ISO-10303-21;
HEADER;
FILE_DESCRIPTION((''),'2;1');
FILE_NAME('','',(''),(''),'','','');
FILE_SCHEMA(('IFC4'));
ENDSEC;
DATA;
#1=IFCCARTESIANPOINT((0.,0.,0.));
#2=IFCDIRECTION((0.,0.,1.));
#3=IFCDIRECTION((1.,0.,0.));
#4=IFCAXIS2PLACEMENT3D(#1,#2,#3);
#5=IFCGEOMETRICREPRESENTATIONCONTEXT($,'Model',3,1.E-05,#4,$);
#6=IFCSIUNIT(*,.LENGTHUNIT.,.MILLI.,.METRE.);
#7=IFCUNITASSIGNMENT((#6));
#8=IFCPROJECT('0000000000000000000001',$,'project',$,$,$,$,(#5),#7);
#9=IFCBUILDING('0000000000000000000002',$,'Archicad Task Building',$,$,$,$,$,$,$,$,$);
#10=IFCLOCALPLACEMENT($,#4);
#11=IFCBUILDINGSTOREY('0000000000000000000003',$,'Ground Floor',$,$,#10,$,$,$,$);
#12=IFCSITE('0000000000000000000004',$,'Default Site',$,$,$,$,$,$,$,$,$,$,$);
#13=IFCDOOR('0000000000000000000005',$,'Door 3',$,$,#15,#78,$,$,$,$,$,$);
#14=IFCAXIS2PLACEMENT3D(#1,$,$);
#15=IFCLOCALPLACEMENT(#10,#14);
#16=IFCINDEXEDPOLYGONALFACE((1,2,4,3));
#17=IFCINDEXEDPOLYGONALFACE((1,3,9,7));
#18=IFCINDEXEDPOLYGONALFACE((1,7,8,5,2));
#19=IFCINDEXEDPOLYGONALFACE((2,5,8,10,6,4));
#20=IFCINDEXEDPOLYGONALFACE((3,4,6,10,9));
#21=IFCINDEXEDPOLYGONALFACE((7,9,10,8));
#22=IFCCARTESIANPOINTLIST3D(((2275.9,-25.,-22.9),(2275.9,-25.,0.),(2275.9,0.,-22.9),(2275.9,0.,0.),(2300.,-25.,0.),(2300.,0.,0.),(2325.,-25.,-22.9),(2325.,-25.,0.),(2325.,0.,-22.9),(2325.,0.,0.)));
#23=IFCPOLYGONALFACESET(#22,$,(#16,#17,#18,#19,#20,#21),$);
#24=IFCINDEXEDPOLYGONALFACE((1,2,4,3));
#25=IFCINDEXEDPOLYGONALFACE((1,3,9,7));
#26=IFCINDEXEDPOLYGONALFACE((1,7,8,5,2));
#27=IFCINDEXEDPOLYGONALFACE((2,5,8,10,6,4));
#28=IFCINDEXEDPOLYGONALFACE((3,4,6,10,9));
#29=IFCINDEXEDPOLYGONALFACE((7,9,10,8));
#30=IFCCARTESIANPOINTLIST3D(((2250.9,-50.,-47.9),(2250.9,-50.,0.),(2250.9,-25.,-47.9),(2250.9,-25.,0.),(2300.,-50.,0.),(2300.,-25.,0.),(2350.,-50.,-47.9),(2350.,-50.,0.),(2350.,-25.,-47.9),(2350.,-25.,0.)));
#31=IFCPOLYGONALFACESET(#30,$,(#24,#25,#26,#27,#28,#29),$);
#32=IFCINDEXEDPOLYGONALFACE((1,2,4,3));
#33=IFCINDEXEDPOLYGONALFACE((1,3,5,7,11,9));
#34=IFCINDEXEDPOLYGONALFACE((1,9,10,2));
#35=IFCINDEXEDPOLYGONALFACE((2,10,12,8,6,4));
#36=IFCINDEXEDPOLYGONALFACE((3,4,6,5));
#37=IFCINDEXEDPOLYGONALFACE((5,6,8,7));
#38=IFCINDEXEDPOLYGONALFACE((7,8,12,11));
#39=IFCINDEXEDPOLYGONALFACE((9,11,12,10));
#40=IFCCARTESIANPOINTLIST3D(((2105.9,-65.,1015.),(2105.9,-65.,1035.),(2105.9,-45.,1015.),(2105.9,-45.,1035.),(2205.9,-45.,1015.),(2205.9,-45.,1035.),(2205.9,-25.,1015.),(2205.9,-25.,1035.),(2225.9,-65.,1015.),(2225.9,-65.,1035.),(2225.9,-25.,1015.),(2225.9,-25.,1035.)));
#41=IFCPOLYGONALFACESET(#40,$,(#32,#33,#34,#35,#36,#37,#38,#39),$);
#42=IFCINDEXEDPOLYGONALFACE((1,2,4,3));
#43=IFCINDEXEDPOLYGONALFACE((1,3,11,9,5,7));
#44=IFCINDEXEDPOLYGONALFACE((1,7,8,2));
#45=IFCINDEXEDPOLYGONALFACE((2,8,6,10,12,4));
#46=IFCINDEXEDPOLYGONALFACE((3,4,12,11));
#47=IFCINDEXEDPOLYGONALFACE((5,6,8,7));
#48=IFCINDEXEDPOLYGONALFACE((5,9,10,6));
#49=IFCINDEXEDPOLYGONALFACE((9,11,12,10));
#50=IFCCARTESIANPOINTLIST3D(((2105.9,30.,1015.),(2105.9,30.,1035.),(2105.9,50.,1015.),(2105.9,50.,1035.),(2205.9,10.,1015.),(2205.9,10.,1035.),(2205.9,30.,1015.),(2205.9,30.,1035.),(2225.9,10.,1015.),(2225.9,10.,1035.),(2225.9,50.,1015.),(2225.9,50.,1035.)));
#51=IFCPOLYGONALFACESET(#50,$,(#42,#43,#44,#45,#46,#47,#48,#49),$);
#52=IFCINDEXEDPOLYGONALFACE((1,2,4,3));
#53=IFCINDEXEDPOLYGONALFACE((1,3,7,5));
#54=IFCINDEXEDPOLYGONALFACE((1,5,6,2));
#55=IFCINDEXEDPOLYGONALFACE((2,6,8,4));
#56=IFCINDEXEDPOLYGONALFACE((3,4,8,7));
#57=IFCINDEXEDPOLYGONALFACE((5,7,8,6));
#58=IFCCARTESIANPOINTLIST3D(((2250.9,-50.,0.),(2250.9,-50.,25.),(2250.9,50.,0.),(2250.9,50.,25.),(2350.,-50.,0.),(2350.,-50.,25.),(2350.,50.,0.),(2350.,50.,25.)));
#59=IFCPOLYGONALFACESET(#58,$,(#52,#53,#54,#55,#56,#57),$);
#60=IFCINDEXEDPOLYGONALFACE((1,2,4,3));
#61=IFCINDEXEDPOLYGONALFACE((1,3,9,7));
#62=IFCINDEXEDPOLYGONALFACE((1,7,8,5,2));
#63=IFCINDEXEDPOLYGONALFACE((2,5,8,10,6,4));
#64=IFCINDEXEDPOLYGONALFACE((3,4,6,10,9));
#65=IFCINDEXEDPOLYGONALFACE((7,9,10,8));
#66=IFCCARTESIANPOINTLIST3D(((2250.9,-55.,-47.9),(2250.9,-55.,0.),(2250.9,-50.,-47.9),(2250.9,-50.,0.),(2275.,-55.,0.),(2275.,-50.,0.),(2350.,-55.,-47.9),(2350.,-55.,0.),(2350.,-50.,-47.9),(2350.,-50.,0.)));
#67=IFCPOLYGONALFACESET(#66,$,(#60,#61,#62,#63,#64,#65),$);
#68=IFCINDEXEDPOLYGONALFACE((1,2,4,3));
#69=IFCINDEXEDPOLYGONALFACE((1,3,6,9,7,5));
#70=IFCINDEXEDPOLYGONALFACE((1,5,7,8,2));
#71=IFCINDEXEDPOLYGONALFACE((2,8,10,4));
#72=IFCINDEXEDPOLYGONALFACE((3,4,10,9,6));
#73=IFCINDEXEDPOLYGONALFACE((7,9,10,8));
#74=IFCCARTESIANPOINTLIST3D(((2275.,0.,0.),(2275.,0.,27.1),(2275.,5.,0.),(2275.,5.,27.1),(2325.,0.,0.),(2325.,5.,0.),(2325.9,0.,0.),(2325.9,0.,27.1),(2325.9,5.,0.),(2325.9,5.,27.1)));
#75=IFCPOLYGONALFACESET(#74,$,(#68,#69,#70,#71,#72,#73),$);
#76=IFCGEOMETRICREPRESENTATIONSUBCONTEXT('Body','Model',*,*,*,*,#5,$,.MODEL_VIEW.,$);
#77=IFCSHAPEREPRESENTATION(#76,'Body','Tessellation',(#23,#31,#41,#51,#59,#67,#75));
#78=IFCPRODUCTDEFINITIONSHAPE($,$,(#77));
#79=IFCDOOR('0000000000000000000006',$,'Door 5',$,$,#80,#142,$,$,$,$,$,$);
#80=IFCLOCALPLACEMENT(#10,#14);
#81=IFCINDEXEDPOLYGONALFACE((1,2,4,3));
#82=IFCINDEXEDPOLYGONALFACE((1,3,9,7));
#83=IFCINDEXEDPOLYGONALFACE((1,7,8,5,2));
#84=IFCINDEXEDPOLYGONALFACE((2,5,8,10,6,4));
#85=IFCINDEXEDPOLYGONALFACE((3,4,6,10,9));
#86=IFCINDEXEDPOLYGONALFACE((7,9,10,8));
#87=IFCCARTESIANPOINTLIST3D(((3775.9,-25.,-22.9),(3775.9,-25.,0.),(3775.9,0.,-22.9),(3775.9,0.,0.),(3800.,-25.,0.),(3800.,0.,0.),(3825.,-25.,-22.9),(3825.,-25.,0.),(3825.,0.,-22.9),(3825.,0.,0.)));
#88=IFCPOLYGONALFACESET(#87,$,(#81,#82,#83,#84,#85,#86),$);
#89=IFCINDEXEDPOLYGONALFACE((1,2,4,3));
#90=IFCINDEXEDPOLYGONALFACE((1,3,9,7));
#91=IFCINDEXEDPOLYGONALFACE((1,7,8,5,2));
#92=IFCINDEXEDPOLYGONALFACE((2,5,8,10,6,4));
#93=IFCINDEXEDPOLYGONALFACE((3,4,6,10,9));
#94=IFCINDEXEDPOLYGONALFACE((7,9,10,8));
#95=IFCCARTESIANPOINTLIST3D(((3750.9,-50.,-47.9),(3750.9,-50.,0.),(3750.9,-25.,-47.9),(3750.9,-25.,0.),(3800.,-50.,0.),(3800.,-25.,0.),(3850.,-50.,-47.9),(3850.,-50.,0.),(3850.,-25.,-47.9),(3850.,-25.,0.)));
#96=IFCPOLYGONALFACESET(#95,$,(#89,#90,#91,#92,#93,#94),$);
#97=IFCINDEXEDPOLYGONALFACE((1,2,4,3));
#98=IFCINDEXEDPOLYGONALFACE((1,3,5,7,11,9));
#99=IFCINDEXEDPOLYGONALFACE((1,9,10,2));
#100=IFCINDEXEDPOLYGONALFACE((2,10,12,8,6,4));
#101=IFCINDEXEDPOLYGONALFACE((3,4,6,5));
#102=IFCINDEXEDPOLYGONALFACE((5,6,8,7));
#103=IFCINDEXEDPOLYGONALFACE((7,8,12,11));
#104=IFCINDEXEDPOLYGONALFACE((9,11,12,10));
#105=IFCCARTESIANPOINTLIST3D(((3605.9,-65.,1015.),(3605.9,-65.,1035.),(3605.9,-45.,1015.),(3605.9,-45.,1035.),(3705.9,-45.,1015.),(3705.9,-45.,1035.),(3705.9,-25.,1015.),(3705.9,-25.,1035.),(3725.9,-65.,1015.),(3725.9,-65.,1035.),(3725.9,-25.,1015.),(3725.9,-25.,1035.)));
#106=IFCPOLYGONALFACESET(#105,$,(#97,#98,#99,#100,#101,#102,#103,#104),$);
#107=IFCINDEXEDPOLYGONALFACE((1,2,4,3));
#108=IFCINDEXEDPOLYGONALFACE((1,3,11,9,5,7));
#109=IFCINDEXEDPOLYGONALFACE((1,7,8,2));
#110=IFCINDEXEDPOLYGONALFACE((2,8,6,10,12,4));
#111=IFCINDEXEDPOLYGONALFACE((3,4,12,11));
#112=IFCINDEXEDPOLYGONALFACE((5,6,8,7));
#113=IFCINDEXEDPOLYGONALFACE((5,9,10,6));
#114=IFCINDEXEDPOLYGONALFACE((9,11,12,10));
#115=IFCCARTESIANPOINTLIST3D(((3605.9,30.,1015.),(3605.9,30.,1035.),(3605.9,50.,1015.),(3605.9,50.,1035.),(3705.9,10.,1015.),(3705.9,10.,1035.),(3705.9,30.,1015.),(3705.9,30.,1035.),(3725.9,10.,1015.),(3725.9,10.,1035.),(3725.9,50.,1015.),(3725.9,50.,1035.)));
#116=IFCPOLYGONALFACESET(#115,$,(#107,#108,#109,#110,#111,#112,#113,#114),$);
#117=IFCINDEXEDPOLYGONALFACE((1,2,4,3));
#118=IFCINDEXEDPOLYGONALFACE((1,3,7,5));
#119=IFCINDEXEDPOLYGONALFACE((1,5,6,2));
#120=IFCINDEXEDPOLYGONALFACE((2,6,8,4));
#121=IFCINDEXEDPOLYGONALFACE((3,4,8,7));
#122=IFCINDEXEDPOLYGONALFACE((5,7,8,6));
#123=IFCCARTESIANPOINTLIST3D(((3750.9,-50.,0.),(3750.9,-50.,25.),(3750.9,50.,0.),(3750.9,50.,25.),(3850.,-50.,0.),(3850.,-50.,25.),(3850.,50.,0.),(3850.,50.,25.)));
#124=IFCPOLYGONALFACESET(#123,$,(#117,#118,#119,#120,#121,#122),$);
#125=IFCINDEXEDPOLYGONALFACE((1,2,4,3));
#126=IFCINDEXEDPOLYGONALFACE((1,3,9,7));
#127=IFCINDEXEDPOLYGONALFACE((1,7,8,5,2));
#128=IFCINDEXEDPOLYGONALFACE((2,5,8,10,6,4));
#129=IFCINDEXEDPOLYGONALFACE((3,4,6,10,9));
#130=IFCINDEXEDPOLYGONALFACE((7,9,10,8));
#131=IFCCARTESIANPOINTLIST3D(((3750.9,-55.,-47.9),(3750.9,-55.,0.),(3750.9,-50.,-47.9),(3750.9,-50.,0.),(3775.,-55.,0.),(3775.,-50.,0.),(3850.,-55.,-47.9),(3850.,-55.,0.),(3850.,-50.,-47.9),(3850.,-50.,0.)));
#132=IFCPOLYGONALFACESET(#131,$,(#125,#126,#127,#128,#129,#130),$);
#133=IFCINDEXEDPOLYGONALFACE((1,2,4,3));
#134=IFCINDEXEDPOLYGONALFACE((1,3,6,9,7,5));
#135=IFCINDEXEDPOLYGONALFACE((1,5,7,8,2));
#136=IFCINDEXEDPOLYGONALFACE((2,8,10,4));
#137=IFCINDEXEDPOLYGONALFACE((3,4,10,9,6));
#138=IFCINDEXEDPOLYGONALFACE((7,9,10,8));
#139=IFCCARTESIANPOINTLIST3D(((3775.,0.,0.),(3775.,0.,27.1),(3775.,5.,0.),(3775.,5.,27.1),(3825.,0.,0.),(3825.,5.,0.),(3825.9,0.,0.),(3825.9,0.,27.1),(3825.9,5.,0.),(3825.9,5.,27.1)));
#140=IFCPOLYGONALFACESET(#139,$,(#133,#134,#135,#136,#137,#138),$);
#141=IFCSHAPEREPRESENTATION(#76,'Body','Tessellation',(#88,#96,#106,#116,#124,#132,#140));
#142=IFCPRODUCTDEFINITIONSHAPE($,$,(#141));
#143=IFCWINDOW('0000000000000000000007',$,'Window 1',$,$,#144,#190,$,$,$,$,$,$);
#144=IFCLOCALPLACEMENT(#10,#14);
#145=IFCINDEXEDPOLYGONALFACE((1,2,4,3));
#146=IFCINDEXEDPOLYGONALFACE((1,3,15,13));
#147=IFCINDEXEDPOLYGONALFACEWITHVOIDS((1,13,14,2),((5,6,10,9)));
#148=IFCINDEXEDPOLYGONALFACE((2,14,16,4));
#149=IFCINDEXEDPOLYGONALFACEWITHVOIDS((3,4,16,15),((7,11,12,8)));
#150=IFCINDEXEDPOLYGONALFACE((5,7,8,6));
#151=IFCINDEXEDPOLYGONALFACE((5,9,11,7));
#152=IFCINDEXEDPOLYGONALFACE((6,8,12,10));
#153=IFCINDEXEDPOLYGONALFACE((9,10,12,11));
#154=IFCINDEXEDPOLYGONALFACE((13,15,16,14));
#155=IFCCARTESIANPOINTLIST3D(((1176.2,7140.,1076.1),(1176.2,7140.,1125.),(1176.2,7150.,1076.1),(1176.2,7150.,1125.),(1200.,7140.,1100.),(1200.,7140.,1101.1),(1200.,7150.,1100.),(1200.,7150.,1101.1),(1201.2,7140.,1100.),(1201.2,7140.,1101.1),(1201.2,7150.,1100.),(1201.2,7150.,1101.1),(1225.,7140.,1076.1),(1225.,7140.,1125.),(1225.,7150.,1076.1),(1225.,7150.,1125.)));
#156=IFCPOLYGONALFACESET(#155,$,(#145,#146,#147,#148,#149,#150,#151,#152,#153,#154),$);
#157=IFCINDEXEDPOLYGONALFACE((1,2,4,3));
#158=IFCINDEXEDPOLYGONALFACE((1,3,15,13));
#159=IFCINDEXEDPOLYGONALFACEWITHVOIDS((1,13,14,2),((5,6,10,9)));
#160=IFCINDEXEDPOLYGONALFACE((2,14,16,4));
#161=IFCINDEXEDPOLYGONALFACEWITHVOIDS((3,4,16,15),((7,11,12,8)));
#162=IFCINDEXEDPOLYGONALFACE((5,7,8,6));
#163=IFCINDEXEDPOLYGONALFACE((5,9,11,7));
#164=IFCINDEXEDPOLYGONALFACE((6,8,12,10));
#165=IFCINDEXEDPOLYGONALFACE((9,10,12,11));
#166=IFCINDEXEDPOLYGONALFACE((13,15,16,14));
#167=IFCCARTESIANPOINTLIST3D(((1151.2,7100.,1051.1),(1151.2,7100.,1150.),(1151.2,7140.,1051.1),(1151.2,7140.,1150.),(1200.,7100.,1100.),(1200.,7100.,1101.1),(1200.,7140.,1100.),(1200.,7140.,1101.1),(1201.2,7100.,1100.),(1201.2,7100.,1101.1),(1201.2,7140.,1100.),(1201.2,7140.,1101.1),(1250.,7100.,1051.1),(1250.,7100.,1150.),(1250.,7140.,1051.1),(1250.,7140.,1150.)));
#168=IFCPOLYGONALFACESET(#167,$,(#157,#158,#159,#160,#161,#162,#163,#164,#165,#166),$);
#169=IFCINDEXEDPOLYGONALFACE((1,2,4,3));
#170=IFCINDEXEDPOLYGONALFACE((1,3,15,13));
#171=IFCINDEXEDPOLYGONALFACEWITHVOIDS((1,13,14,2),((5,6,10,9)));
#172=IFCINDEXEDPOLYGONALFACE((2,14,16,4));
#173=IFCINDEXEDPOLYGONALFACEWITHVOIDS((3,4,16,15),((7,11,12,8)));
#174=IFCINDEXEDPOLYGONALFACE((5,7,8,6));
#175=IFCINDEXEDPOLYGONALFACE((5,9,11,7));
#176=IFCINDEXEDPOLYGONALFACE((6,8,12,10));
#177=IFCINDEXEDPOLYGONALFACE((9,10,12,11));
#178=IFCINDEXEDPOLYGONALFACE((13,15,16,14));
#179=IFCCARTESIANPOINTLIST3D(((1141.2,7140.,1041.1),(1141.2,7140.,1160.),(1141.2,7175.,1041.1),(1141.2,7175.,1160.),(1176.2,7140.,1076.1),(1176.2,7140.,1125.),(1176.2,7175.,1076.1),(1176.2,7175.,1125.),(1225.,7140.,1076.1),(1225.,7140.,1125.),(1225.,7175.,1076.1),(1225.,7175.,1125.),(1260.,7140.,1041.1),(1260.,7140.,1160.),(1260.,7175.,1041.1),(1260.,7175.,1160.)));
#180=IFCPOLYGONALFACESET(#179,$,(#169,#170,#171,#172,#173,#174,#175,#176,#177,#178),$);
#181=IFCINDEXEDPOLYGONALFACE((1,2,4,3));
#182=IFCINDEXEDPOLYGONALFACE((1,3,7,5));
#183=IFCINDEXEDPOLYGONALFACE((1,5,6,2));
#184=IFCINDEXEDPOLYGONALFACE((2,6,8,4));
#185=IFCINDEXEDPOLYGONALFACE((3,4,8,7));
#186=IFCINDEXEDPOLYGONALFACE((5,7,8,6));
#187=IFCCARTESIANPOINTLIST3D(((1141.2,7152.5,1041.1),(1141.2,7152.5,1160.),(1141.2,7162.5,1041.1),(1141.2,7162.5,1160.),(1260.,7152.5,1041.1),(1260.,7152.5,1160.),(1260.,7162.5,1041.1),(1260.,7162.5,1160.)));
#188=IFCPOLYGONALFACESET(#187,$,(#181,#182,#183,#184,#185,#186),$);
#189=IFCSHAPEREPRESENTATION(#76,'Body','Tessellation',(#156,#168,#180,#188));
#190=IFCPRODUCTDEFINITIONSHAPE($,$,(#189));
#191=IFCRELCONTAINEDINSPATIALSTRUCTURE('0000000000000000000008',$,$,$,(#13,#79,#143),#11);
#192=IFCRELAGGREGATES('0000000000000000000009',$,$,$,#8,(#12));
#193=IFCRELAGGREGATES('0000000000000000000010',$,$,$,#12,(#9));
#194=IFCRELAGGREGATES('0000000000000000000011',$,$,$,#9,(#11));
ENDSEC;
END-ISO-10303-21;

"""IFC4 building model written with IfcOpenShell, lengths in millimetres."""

from ifc_helpers import new_model, si_unit, frame, origin_with_axes, place, context, subcontext, project, spatial, line, indexed_curve, outline, extrude, element, save


model = new_model("IFC4")

# Units and contexts
model_context = context("Model", 3, precision=1e-05, world=origin_with_axes())
body_context = subcontext(model_context, "Body", "Model", "MODEL_VIEW")
ifc_project = project(units=[si_unit("LENGTHUNIT", "METRE", prefix="MILLI")], contexts=[model_context])

# Site, building, storey
site = spatial("IfcSite", under=ifc_project, Name="Default Site")
building = spatial("IfcBuilding", under=site, Name="Archicad Task Building")
storey_placement = place(None, origin_with_axes())
storey = spatial("IfcBuildingStorey", under=building, at=storey_placement, Name="Ground Floor")

# Doors
door_1_placement = place(storey_placement, frame((2300.0, -50.0, 0.0), z_axis=(0.0, 0.0, 1.0), x_axis=(1.0, 0.0, 0.0)))
element("IfcDoor", 1, at=door_1_placement, inside=storey, Name="Door 3", context=body_context, shape_type="SweptSolid", body=[
    extrude(outline(indexed_curve([(0.0, 0.0), (0.0, 2.1), (0.9, 2.1), (0.9, 0.0), (-24.1, 0.0), (-24.1, -22.9), (25.0, -22.9), (25.0, 0.0)], segments=[line(1, 2, 3, 4, 5, 6, 7, 8, 1)])), frame((0.0, 25.0, 0.0), z_axis=(0.0, -1.0, 0.0), x_axis=(1.0, 0.0, 0.0)), (0.0, 0.0, -1.0), 25.0),
    extrude(outline(indexed_curve([(0.0, 0.0), (0.0, 2.1), (0.9, 2.1), (0.9, 0.0), (-49.1, 0.0), (-49.1, -47.9), (50.0, -47.9), (50.0, 0.0)], segments=[line(1, 2, 3, 4, 5, 6, 7, 8, 1)])), frame((0.0, 0.0, 0.0), z_axis=(0.0, -1.0, 0.0), x_axis=(1.0, 0.0, 0.0)), (0.0, 0.0, -1.0), 25.0),
    extrude(outline(indexed_curve([(0.0, 0.0), (-49.1, 0.0), (-49.1, 35.0), (0.0, 35.0)], segments=[line(1, 2, 3, 4, 1)])), frame((25.0, 25.0, 25.0), z_axis=(0.0, 0.0, 1.0), x_axis=(1.0, 0.0, 0.0)), (0.0, 0.0, 1.0), -47.9),
    extrude(outline(indexed_curve([(0.0, 0.0), (0.0, -40.0), (-120.0, -40.0), (-120.0, -20.0), (-20.0, -20.0), (-20.0, 0.0)], segments=[line(1, 2, 3, 4, 5, 6, 1)])), frame((-74.1, 25.0, 1015.0), z_axis=(0.0, 0.0, 1.0), x_axis=(1.0, 0.0, 0.0)), (0.0, 0.0, 1.0), 20.0),
    extrude(outline(indexed_curve([(0.0, 0.0), (0.0, 40.0), (-120.0, 40.0), (-120.0, 20.0), (-20.0, 20.0), (-20.0, 0.0)], segments=[line(1, 2, 3, 4, 5, 6, 1)])), frame((-74.1, 60.0, 1015.0), z_axis=(0.0, 0.0, 1.0), x_axis=(1.0, 0.0, 0.0)), (0.0, 0.0, 1.0), 20.0),
    extrude(outline(indexed_curve([(0.0, 0.0), (-99.1, 0.0), (-99.1, 100.0), (0.0, 100.0)], segments=[line(1, 2, 3, 4, 1)])), frame((50.0, 0.0, 0.0), z_axis=(0.0, 0.0, 1.0), x_axis=(1.0, 0.0, 0.0)), (0.0, 0.0, 1.0), 25.0),
    extrude(outline(indexed_curve([(0.0, 0.0), (0.0, 27.1), (50.9, 27.1), (50.9, 0.0), (-24.1, 0.0), (-24.1, -47.9), (75.0, -47.9), (75.0, 0.0)], segments=[line(1, 2, 3, 4, 5, 6, 7, 8, 1)])), frame((-25.0, -5.0, 0.0), z_axis=(0.0, -1.0, 0.0), x_axis=(1.0, 0.0, 0.0)), (0.0, 0.0, -1.0), 5.0),
    extrude(outline(indexed_curve([(0.0, 0.0), (0.0, 27.1), (50.9, 27.1), (50.9, 0.0), (0.9, 0.0), (0.9, -22.9), (50.0, -22.9), (50.0, 0.0)], segments=[line(1, 2, 3, 4, 5, 6, 7, 8, 1)])), frame((-25.0, 50.0, 0.0), z_axis=(0.0, -1.0, 0.0), x_axis=(1.0, 0.0, 0.0)), (0.0, 0.0, -1.0), 5.0),
])
door_2_placement = place(storey_placement, frame((3800.0, -50.0, 0.0), z_axis=(0.0, 0.0, 1.0), x_axis=(1.0, 0.0, 0.0)))
element("IfcDoor", 2, at=door_2_placement, inside=storey, Name="Door 5", context=body_context, shape_type="SweptSolid", body=[
    extrude(outline(indexed_curve([(0.0, 0.0), (0.0, 2.1), (0.9, 2.1), (0.9, 0.0), (-24.1, 0.0), (-24.1, -22.9), (25.0, -22.9), (25.0, 0.0)], segments=[line(1, 2, 3, 4, 5, 6, 7, 8, 1)])), frame((0.0, 25.0, 0.0), z_axis=(0.0, -1.0, 0.0), x_axis=(1.0, 0.0, 0.0)), (0.0, 0.0, -1.0), 25.0),
    extrude(outline(indexed_curve([(0.0, 0.0), (0.0, 2.1), (0.9, 2.1), (0.9, 0.0), (-49.1, 0.0), (-49.1, -47.9), (50.0, -47.9), (50.0, 0.0)], segments=[line(1, 2, 3, 4, 5, 6, 7, 8, 1)])), frame((0.0, 0.0, 0.0), z_axis=(0.0, -1.0, 0.0), x_axis=(1.0, 0.0, 0.0)), (0.0, 0.0, -1.0), 25.0),
    extrude(outline(indexed_curve([(0.0, 0.0), (-49.1, 0.0), (-49.1, 35.0), (0.0, 35.0)], segments=[line(1, 2, 3, 4, 1)])), frame((25.0, 25.0, 25.0), z_axis=(0.0, 0.0, 1.0), x_axis=(1.0, 0.0, 0.0)), (0.0, 0.0, 1.0), -47.9),
    extrude(outline(indexed_curve([(0.0, 0.0), (0.0, -40.0), (-120.0, -40.0), (-120.0, -20.0), (-20.0, -20.0), (-20.0, 0.0)], segments=[line(1, 2, 3, 4, 5, 6, 1)])), frame((-74.1, 25.0, 1015.0), z_axis=(0.0, 0.0, 1.0), x_axis=(1.0, 0.0, 0.0)), (0.0, 0.0, 1.0), 20.0),
    extrude(outline(indexed_curve([(0.0, 0.0), (0.0, 40.0), (-120.0, 40.0), (-120.0, 20.0), (-20.0, 20.0), (-20.0, 0.0)], segments=[line(1, 2, 3, 4, 5, 6, 1)])), frame((-74.1, 60.0, 1015.0), z_axis=(0.0, 0.0, 1.0), x_axis=(1.0, 0.0, 0.0)), (0.0, 0.0, 1.0), 20.0),
    extrude(outline(indexed_curve([(0.0, 0.0), (-99.1, 0.0), (-99.1, 100.0), (0.0, 100.0)], segments=[line(1, 2, 3, 4, 1)])), frame((50.0, 0.0, 0.0), z_axis=(0.0, 0.0, 1.0), x_axis=(1.0, 0.0, 0.0)), (0.0, 0.0, 1.0), 25.0),
    extrude(outline(indexed_curve([(0.0, 0.0), (0.0, 27.1), (50.9, 27.1), (50.9, 0.0), (-24.1, 0.0), (-24.1, -47.9), (75.0, -47.9), (75.0, 0.0)], segments=[line(1, 2, 3, 4, 5, 6, 7, 8, 1)])), frame((-25.0, -5.0, 0.0), z_axis=(0.0, -1.0, 0.0), x_axis=(1.0, 0.0, 0.0)), (0.0, 0.0, -1.0), 5.0),
    extrude(outline(indexed_curve([(0.0, 0.0), (0.0, 27.1), (50.9, 27.1), (50.9, 0.0), (0.9, 0.0), (0.9, -22.9), (50.0, -22.9), (50.0, 0.0)], segments=[line(1, 2, 3, 4, 5, 6, 7, 8, 1)])), frame((-25.0, 50.0, 0.0), z_axis=(0.0, -1.0, 0.0), x_axis=(1.0, 0.0, 0.0)), (0.0, 0.0, -1.0), 5.0),
])

# Window
for number, where, z_axis, x_axis, name in (
    (3, (1200.0, 7050.0, 1100.0), (0.0, 0.0, 1.0), (1.0, 0.0, 0.0), "Window 1"),
):
    element("IfcWindow", number, at=place(storey_placement, frame(where, z_axis=z_axis, x_axis=x_axis)), inside=storey, Name=name, context=body_context, shape_type="SweptSolid", body=[
        extrude(outline(indexed_curve([(0.0, 0.0), (1.2, 0.0), (1.2, 1.1), (0.0, 1.1)], segments=[line(1, 2, 3, 4, 1)]), holes=[indexed_curve([(25.0, 25.0), (-23.8, 25.0), (-23.8, -23.9), (25.0, -23.9)], segments=[line(1, 2, 3, 4, 1)])]), frame((0.0, 90.0, 0.0), z_axis=(0.0, -1.0, 0.0), x_axis=(1.0, 0.0, 0.0)), (0.0, 0.0, -1.0), 10.0),
        extrude(outline(indexed_curve([(0.0, 0.0), (1.2, 0.0), (1.2, 1.1), (0.0, 1.1)], segments=[line(1, 2, 3, 4, 1)]), holes=[indexed_curve([(50.0, 50.0), (-48.8, 50.0), (-48.8, -48.9), (50.0, -48.9)], segments=[line(1, 2, 3, 4, 1)])]), frame((0.0, 50.0, 0.0), z_axis=(0.0, -1.0, 0.0), x_axis=(1.0, 0.0, 0.0)), (0.0, 0.0, -1.0), 40.0),
        extrude(outline(indexed_curve([(0.0, 0.0), (-48.8, 0.0), (-48.8, -48.9), (0.0, -48.9)], segments=[line(1, 2, 3, 4, 1)]), holes=[indexed_curve([(35.0, 35.0), (-83.8, 35.0), (-83.8, -83.9), (35.0, -83.9)], segments=[line(1, 2, 3, 4, 1)])]), frame((25.0, 90.0, 25.0), z_axis=(0.0, -1.0, 0.0), x_axis=(1.0, 0.0, 0.0)), (0.0, 0.0, -1.0), 35.0),
        extrude(outline(indexed_curve([(35.0, 35.0), (-83.8, 35.0), (-83.8, -83.9), (35.0, -83.9)], segments=[line(1, 2, 3, 4, 1)])), frame((25.0, 102.5, 25.0), z_axis=(0.0, -1.0, 0.0), x_axis=(1.0, 0.0, 0.0)), (0.0, 0.0, -1.0), 10.0),
    ])

save(model, "model.ifc")
